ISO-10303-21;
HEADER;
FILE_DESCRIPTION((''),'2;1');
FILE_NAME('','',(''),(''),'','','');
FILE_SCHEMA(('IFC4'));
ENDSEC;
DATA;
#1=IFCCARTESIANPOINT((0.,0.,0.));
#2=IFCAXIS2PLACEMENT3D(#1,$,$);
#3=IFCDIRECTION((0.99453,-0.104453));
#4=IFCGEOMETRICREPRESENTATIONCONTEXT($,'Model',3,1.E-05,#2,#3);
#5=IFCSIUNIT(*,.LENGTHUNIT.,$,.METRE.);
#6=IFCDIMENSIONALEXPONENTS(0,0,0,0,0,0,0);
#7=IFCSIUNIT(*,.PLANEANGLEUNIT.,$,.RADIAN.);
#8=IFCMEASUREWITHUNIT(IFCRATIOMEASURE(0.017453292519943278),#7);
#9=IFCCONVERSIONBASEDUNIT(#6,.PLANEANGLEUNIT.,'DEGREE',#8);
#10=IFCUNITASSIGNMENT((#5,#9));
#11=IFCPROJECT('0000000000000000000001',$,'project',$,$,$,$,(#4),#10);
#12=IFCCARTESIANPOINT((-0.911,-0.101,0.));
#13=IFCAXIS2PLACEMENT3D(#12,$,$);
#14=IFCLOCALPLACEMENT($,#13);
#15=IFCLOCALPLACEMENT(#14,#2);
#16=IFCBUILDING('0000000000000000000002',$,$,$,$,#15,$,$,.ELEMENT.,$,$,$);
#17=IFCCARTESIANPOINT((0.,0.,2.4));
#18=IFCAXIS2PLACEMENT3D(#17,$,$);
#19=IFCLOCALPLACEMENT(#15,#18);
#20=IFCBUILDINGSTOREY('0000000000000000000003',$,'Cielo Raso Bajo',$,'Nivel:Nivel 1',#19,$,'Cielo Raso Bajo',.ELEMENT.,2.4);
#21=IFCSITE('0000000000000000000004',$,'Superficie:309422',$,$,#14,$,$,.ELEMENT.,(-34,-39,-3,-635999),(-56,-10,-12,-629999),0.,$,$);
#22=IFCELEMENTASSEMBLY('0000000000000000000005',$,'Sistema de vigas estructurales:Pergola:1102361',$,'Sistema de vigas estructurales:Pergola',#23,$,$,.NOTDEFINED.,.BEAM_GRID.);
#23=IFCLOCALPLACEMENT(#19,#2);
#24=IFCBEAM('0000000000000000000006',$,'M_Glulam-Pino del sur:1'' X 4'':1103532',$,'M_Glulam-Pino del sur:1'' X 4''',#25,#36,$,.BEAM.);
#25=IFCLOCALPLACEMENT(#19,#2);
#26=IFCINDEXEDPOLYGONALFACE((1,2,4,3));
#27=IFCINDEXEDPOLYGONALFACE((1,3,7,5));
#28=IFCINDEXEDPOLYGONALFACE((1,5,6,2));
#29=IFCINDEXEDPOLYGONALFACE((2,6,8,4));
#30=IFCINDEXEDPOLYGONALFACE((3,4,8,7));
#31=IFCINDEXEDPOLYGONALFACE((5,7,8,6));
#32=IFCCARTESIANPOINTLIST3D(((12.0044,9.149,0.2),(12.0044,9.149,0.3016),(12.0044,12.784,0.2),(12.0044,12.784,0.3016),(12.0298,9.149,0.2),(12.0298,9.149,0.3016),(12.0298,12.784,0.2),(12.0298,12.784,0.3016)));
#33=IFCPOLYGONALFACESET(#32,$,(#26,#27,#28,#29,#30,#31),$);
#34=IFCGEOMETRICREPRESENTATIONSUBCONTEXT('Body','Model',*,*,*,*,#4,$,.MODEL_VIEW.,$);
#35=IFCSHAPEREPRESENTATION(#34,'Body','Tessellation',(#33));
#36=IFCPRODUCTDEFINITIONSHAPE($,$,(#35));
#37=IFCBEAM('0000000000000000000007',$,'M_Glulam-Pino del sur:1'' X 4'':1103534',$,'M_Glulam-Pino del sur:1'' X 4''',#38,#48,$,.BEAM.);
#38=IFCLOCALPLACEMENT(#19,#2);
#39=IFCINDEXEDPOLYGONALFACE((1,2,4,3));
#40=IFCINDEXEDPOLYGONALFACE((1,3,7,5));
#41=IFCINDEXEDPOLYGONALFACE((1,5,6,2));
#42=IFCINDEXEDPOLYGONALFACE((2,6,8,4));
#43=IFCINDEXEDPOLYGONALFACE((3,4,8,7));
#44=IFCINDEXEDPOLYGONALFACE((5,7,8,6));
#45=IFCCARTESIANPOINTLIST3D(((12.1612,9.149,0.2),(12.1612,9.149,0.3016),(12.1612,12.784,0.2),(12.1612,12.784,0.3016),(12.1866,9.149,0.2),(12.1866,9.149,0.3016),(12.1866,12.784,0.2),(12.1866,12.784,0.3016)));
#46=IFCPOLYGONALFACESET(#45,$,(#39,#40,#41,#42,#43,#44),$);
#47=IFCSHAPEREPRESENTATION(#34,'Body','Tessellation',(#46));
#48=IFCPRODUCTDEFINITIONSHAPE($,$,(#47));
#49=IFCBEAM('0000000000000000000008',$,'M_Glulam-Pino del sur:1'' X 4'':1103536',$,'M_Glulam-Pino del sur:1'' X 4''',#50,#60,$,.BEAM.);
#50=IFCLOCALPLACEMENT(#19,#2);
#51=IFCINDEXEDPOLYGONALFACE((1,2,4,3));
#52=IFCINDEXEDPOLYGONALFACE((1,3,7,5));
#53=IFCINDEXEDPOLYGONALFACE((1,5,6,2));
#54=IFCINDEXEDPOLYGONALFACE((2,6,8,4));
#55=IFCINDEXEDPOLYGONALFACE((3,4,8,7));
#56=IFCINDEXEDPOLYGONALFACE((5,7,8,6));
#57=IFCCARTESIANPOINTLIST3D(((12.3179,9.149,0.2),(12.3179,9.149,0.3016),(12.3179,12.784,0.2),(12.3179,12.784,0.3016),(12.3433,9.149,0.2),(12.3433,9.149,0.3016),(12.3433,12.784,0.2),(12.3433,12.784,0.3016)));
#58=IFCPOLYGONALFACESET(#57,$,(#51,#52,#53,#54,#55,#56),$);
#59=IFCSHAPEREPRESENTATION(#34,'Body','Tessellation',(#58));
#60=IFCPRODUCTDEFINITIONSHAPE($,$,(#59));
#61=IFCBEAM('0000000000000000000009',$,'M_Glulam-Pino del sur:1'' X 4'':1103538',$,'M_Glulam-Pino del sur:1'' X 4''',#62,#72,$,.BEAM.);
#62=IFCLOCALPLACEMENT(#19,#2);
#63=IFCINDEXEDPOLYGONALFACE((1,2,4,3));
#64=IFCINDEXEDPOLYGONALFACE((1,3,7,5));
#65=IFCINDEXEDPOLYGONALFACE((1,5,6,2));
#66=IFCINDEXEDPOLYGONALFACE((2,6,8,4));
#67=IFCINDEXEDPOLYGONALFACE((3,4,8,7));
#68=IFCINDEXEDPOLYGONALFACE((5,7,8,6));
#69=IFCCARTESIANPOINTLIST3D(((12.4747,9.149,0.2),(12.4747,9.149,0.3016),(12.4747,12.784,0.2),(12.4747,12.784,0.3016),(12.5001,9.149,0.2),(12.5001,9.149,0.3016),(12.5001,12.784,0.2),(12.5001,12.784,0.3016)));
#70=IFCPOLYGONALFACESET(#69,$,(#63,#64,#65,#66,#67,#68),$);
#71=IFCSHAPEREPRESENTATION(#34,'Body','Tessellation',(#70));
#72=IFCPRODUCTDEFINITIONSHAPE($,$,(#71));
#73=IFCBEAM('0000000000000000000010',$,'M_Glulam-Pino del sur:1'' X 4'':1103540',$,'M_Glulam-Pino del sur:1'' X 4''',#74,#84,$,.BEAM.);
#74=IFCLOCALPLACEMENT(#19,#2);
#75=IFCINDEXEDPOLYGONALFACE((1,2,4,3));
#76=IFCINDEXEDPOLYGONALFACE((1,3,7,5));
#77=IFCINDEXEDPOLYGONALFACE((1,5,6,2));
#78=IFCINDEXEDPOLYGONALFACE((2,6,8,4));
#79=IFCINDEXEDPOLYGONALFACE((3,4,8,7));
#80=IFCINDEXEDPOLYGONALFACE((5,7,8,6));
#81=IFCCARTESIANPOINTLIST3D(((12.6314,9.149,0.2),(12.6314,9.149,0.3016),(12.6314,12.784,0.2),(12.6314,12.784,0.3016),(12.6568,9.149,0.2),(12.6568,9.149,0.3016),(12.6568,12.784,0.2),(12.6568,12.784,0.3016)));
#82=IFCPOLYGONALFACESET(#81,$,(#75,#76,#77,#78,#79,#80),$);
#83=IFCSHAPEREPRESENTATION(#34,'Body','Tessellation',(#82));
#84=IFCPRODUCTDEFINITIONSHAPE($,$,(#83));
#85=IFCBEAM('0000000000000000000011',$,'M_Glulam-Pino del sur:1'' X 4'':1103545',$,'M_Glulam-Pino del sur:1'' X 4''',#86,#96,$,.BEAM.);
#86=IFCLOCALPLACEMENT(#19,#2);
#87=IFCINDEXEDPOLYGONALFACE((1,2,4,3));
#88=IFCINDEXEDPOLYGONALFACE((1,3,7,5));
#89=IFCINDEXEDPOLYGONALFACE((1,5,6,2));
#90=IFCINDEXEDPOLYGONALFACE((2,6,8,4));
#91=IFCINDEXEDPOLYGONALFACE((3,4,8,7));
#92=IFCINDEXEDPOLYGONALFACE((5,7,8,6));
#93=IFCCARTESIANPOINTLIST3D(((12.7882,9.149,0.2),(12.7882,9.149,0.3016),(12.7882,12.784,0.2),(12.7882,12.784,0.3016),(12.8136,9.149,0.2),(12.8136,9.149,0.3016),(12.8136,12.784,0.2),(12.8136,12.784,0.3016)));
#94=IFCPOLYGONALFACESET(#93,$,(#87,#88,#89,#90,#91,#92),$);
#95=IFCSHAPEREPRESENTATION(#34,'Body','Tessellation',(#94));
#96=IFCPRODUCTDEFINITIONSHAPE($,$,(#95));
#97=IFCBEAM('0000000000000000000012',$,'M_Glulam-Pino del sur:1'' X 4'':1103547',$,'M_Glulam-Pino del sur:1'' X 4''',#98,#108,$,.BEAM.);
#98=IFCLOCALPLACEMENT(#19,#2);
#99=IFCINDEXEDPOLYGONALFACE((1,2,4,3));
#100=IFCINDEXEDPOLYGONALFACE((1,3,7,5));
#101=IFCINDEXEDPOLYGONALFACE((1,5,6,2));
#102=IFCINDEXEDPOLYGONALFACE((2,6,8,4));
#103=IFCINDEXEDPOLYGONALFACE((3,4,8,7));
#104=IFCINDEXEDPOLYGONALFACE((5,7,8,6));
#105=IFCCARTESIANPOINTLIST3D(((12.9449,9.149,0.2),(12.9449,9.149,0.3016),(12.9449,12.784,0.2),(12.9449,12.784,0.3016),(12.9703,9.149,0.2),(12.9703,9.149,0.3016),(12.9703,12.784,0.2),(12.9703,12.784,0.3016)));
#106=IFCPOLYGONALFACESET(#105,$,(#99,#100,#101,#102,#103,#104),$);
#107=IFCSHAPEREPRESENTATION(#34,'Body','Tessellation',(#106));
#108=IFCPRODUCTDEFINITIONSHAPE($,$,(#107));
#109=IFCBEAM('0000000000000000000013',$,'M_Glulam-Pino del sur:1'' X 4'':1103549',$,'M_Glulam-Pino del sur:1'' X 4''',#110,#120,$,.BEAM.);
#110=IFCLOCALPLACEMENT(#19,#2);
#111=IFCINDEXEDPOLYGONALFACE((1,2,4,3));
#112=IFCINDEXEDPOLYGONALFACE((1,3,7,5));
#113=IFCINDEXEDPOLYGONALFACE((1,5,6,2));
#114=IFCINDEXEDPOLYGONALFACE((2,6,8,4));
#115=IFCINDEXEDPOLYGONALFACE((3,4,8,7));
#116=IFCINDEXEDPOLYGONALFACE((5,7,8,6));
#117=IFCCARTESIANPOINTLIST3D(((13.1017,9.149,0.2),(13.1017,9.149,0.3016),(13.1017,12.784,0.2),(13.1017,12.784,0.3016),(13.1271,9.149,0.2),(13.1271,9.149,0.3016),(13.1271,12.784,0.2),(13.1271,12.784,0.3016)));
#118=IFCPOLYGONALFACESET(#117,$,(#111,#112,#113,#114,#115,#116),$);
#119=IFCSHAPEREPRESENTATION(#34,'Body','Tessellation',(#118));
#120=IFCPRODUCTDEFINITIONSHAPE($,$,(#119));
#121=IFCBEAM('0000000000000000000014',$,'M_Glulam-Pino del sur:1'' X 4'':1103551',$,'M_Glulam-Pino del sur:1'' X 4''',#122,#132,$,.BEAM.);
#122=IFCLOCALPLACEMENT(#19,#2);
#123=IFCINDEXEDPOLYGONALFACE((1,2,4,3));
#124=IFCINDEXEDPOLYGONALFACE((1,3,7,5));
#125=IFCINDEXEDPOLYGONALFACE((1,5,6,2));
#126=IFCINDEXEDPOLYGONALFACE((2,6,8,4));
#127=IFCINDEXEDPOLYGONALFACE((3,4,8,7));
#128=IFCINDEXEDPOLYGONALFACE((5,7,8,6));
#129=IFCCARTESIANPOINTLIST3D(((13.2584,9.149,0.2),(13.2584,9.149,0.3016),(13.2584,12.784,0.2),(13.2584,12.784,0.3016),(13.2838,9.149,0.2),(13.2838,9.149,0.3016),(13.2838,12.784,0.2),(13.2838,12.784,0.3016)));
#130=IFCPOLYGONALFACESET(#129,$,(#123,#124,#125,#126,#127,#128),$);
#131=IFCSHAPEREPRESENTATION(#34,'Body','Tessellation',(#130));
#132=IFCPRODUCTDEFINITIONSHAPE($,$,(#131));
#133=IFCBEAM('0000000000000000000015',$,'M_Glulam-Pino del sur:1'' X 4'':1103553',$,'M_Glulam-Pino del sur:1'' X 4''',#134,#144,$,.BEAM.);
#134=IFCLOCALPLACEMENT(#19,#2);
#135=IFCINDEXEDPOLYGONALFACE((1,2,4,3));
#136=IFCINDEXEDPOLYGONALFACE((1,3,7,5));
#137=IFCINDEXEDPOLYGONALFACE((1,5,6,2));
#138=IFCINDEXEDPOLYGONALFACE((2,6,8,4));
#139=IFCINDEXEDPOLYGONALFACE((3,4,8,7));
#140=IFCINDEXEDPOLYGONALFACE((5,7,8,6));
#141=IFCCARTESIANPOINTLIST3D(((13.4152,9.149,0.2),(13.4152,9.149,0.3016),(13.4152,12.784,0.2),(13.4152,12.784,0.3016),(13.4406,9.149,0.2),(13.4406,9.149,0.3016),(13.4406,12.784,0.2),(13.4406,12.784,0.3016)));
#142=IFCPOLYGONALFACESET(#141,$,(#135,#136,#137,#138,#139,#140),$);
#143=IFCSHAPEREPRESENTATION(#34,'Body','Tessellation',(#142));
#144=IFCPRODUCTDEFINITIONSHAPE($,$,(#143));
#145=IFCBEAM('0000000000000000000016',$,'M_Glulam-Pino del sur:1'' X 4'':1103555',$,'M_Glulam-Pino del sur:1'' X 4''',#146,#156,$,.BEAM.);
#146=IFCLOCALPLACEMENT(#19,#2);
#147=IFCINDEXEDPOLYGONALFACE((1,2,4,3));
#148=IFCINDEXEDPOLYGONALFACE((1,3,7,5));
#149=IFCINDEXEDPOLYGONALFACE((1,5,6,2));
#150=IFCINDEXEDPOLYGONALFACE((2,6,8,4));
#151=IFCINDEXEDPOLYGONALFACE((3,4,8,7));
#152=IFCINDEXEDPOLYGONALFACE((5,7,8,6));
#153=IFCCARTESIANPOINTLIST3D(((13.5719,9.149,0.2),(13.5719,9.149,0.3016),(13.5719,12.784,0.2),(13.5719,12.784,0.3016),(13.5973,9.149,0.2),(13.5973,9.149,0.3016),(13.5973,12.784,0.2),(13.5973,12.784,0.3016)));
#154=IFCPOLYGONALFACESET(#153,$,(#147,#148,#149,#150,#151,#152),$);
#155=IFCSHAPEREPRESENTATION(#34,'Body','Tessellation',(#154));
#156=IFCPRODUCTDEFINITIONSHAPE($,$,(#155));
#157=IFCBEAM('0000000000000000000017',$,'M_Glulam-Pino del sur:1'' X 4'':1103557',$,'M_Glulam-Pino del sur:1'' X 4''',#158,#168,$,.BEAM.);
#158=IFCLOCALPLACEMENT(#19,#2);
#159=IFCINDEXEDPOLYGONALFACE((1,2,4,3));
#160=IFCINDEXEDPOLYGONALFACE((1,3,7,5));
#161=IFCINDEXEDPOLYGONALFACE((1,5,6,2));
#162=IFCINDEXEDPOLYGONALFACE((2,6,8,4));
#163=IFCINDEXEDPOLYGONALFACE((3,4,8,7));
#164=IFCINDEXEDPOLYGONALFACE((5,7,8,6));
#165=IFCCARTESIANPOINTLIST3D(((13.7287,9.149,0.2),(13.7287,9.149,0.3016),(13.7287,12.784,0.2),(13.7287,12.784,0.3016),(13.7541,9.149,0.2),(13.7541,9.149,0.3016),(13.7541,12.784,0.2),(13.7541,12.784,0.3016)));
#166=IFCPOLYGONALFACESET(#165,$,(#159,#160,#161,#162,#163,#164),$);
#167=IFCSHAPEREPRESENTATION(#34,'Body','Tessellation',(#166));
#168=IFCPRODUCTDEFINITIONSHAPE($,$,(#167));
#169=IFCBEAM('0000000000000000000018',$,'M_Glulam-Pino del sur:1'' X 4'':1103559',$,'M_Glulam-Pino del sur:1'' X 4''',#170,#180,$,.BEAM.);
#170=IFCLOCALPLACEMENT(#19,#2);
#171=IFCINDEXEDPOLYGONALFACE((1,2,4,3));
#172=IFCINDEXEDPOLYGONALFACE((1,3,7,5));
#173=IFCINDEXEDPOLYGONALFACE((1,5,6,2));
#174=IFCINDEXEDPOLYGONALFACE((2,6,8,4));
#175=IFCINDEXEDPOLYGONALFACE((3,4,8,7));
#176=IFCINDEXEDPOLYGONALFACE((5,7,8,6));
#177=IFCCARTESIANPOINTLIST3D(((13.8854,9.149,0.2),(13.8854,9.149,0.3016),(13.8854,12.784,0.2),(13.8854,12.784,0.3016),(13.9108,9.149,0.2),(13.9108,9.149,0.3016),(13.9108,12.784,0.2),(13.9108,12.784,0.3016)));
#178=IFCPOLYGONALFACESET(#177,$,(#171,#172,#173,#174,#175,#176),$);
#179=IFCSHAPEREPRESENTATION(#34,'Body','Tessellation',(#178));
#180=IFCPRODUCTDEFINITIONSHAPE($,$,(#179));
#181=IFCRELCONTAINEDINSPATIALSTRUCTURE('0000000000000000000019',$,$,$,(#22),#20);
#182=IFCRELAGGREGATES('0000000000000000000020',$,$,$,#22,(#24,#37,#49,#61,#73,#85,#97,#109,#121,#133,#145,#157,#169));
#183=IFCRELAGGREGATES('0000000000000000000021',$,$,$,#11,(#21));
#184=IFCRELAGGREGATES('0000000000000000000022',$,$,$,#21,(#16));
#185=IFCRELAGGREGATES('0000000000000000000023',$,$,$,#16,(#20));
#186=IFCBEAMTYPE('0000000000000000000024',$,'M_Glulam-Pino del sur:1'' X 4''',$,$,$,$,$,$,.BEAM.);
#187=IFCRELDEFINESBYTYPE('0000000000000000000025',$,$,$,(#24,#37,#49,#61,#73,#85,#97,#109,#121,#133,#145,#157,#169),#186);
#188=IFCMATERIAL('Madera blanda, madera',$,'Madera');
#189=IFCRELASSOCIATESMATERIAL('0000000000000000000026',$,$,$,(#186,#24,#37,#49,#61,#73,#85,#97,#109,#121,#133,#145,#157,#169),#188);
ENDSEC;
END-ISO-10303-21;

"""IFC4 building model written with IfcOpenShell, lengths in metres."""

from ifc_helpers import new_model, entity, si_unit, converted_unit, direction, frame, origin, origin_2d_with_axis, place, context, subcontext, project, spatial, polyline, segment, composite_curve, rectangle, outline, extrude, source, transform, mapped, material, material_profile, profile_set, profile_usage, type_object, type_shapes, element, aggregate, save


model = new_model("IFC4")

# Units and contexts
model_context = context("Model", 3, precision=1e-05, world=origin(), true_north=direction((0.99453, -0.104453)))
body_context = subcontext(model_context, "Body", "Model", "MODEL_VIEW")
ifc_project = project(units=[si_unit("LENGTHUNIT", "METRE"), converted_unit("PLANEANGLEUNIT", "DEGREE", entity("IfcRatioMeasure", 0.017453292519943278), si_unit("PLANEANGLEUNIT", "RADIAN"), dimensions=[0, 0, 0, 0, 0, 0, 0])], contexts=[model_context])

# Site, building, storey
site_placement = place(None, frame((-0.911, -0.101, 0.0)))
site = spatial("IfcSite", under=ifc_project, at=site_placement, Name="Superficie:309422", CompositionType="ELEMENT", RefLatitude=(-34, -39, -3, -635999), RefLongitude=(-56, -10, -12, -629999), RefElevation=0.0)
building_placement = place(site_placement, origin())
building = spatial("IfcBuilding", under=site, at=building_placement, CompositionType="ELEMENT")
storey_placement = place(building_placement, frame((0.0, 0.0, 2.4)))
storey = spatial("IfcBuildingStorey", under=building, at=storey_placement, Name="Cielo Raso Bajo", ObjectType="Nivel:Nivel 1", LongName="Cielo Raso Bajo", CompositionType="ELEMENT", Elevation=2.4)

# Element assembly, beams
assembly_placement = place(storey_placement, origin())
assembly = element("IfcElementAssembly", 1, at=assembly_placement, inside=storey, Name="Sistema de vigas estructurales:Pergola:1102361", ObjectType="Sistema de vigas estructurales:Pergola", AssemblyPlace="NOTDEFINED", PredefinedType="BEAM_GRID")
ifc_material = material(Name="Madera blanda, madera", Category="Madera")
ifc_material_profile_1 = material_profile(ifc_material, outline(composite_curve([segment(polyline([(-0.0127, 0.0508, 0.0), (0.0127, 0.0508, 0.0)]), True, "CONTINUOUS"), segment(polyline([(0.0127, 0.0508, 0.0), (0.0127, -0.0508, 0.0)]), True, "CONTINUOUS"), segment(polyline([(0.0127, -0.0508, 0.0), (-0.0127, -0.0508, 0.0)]), True, "CONTINUOUS"), segment(polyline([(-0.0127, -0.0508, 0.0), (-0.0127, 0.0508, 0.0)]), True, "CONTINUOUS")], self_intersect=False), kind="CURVE"), Name="1' X 4'")
ifc_material_profile_2 = material_profile(ifc_material, outline(composite_curve([segment(polyline([(2.5145, -0.0127, -0.0508), (2.5145, -0.0127, 0.0508)]), True, "CONTINUOUS"), segment(polyline([(2.5145, -0.0127, 0.0508), (-2.5145, -0.0127, 0.0508)]), True, "CONTINUOUS"), segment(polyline([(-2.5145, -0.0127, 0.0508), (-2.5145, -0.0127, -0.0508)]), True, "CONTINUOUS"), segment(polyline([(-2.5145, -0.0127, -0.0508), (2.5145, -0.0127, -0.0508)]), True, "CONTINUOUS")], self_intersect=False), kind="CURVE"), Name="1' X 4'")
ifc_profile_set = profile_set([ifc_material_profile_1, ifc_material_profile_2], Name="1' X 4'")
ifc_profile_usage_1 = profile_usage(ifc_profile_set, cardinal=8)
beam_type = type_object("IfcBeamType", Name="M_Glulam-Pino del sur:1' X 4'", PredefinedType="BEAM", material=ifc_profile_set)
shared_shape = source(origin(), body_context, "Body", "SweptSolid", [
    extrude(rectangle(XDim=0.1016, YDim=0.0254, at=origin_2d_with_axis()), frame((-1.7485, 0.0, 0.0), z_axis=(1.0, 0.0, 0.0), x_axis=(0.0, 0.0, -1.0)), (0.0, 0.0, 1.0), 3.635),
])
type_shapes(beam_type, [shared_shape])
beam_1_placement = place(assembly_placement, frame((12.0171, 10.8975, 0.2508), z_axis=(0.0, 0.0, 1.0), x_axis=(0.0, 1.0, 0.0)))
beam_1 = element("IfcBeam", 2, at=beam_1_placement, type_object=beam_type, material=ifc_profile_usage_1, Name="M_Glulam-Pino del sur:1' X 4':1103532", ObjectType="M_Glulam-Pino del sur:1' X 4'", PredefinedType="BEAM", context=body_context, shape_type="MappedRepresentation", body=[
    mapped(shared_shape, transform((0.0, 0.0, 0.0), scale=1.0)),
])
ifc_profile_usage_2 = profile_usage(ifc_profile_set, cardinal=8)
beam_2_placement = place(assembly_placement, frame((12.1739, 10.8975, 0.2508), z_axis=(0.0, 0.0, 1.0), x_axis=(0.0, 1.0, 0.0)))
beam_2 = element("IfcBeam", 3, at=beam_2_placement, type_object=beam_type, material=ifc_profile_usage_2, Name="M_Glulam-Pino del sur:1' X 4':1103534", ObjectType="M_Glulam-Pino del sur:1' X 4'", PredefinedType="BEAM", context=body_context, shape_type="MappedRepresentation", body=[
    mapped(shared_shape, transform((0.0, 0.0, 0.0), scale=1.0)),
])
ifc_profile_usage_3 = profile_usage(ifc_profile_set, cardinal=8)
beam_3_placement = place(assembly_placement, frame((12.3306, 10.8975, 0.2508), z_axis=(0.0, 0.0, 1.0), x_axis=(0.0, 1.0, 0.0)))
beam_3 = element("IfcBeam", 4, at=beam_3_placement, type_object=beam_type, material=ifc_profile_usage_3, Name="M_Glulam-Pino del sur:1' X 4':1103536", ObjectType="M_Glulam-Pino del sur:1' X 4'", PredefinedType="BEAM", context=body_context, shape_type="MappedRepresentation", body=[
    mapped(shared_shape, transform((0.0, 0.0, 0.0), scale=1.0)),
])
ifc_profile_usage_4 = profile_usage(ifc_profile_set, cardinal=8)
beam_4_placement = place(assembly_placement, frame((12.4874, 10.8975, 0.2508), z_axis=(0.0, 0.0, 1.0), x_axis=(0.0, 1.0, 0.0)))
beam_4 = element("IfcBeam", 5, at=beam_4_placement, type_object=beam_type, material=ifc_profile_usage_4, Name="M_Glulam-Pino del sur:1' X 4':1103538", ObjectType="M_Glulam-Pino del sur:1' X 4'", PredefinedType="BEAM", context=body_context, shape_type="MappedRepresentation", body=[
    mapped(shared_shape, transform((0.0, 0.0, 0.0), scale=1.0)),
])
ifc_profile_usage_5 = profile_usage(ifc_profile_set, cardinal=8)
beam_5_placement = place(assembly_placement, frame((12.6441, 10.8975, 0.2508), z_axis=(0.0, 0.0, 1.0), x_axis=(0.0, 1.0, 0.0)))
beam_5 = element("IfcBeam", 6, at=beam_5_placement, type_object=beam_type, material=ifc_profile_usage_5, Name="M_Glulam-Pino del sur:1' X 4':1103540", ObjectType="M_Glulam-Pino del sur:1' X 4'", PredefinedType="BEAM", context=body_context, shape_type="MappedRepresentation", body=[
    mapped(shared_shape, transform((0.0, 0.0, 0.0), scale=1.0)),
])
ifc_profile_usage_6 = profile_usage(ifc_profile_set, cardinal=8)
beam_6_placement = place(assembly_placement, frame((12.8009, 10.8975, 0.2508), z_axis=(0.0, 0.0, 1.0), x_axis=(0.0, 1.0, 0.0)))
beam_6 = element("IfcBeam", 7, at=beam_6_placement, type_object=beam_type, material=ifc_profile_usage_6, Name="M_Glulam-Pino del sur:1' X 4':1103545", ObjectType="M_Glulam-Pino del sur:1' X 4'", PredefinedType="BEAM", context=body_context, shape_type="MappedRepresentation", body=[
    mapped(shared_shape, transform((0.0, 0.0, 0.0), scale=1.0)),
])
ifc_profile_usage_7 = profile_usage(ifc_profile_set, cardinal=8)
beam_7_placement = place(assembly_placement, frame((12.9576, 10.8975, 0.2508), z_axis=(0.0, 0.0, 1.0), x_axis=(0.0, 1.0, 0.0)))
beam_7 = element("IfcBeam", 8, at=beam_7_placement, type_object=beam_type, material=ifc_profile_usage_7, Name="M_Glulam-Pino del sur:1' X 4':1103547", ObjectType="M_Glulam-Pino del sur:1' X 4'", PredefinedType="BEAM", context=body_context, shape_type="MappedRepresentation", body=[
    mapped(shared_shape, transform((0.0, 0.0, 0.0), scale=1.0)),
])
ifc_profile_usage_8 = profile_usage(ifc_profile_set, cardinal=8)
beam_8_placement = place(assembly_placement, frame((13.1144, 10.8975, 0.2508), z_axis=(0.0, 0.0, 1.0), x_axis=(0.0, 1.0, 0.0)))
beam_8 = element("IfcBeam", 9, at=beam_8_placement, type_object=beam_type, material=ifc_profile_usage_8, Name="M_Glulam-Pino del sur:1' X 4':1103549", ObjectType="M_Glulam-Pino del sur:1' X 4'", PredefinedType="BEAM", context=body_context, shape_type="MappedRepresentation", body=[
    mapped(shared_shape, transform((0.0, 0.0, 0.0), scale=1.0)),
])
ifc_profile_usage_9 = profile_usage(ifc_profile_set, cardinal=8)
beam_9_placement = place(assembly_placement, frame((13.2711, 10.8975, 0.2508), z_axis=(0.0, 0.0, 1.0), x_axis=(0.0, 1.0, 0.0)))
beam_9 = element("IfcBeam", 10, at=beam_9_placement, type_object=beam_type, material=ifc_profile_usage_9, Name="M_Glulam-Pino del sur:1' X 4':1103551", ObjectType="M_Glulam-Pino del sur:1' X 4'", PredefinedType="BEAM", context=body_context, shape_type="MappedRepresentation", body=[
    mapped(shared_shape, transform((0.0, 0.0, 0.0), scale=1.0)),
])
ifc_profile_usage_10 = profile_usage(ifc_profile_set, cardinal=8)
beam_10_placement = place(assembly_placement, frame((13.4279, 10.8975, 0.2508), z_axis=(0.0, 0.0, 1.0), x_axis=(0.0, 1.0, 0.0)))
beam_10 = element("IfcBeam", 11, at=beam_10_placement, type_object=beam_type, material=ifc_profile_usage_10, Name="M_Glulam-Pino del sur:1' X 4':1103553", ObjectType="M_Glulam-Pino del sur:1' X 4'", PredefinedType="BEAM", context=body_context, shape_type="MappedRepresentation", body=[
    mapped(shared_shape, transform((0.0, 0.0, 0.0), scale=1.0)),
])
ifc_profile_usage_11 = profile_usage(ifc_profile_set, cardinal=8)
beam_11_placement = place(assembly_placement, frame((13.5846, 10.8975, 0.2508), z_axis=(0.0, 0.0, 1.0), x_axis=(0.0, 1.0, 0.0)))
beam_11 = element("IfcBeam", 12, at=beam_11_placement, type_object=beam_type, material=ifc_profile_usage_11, Name="M_Glulam-Pino del sur:1' X 4':1103555", ObjectType="M_Glulam-Pino del sur:1' X 4'", PredefinedType="BEAM", context=body_context, shape_type="MappedRepresentation", body=[
    mapped(shared_shape, transform((0.0, 0.0, 0.0), scale=1.0)),
])
ifc_profile_usage_12 = profile_usage(ifc_profile_set, cardinal=8)
beam_12_placement = place(assembly_placement, frame((13.7414, 10.8975, 0.2508), z_axis=(0.0, 0.0, 1.0), x_axis=(0.0, 1.0, 0.0)))
beam_12 = element("IfcBeam", 13, at=beam_12_placement, type_object=beam_type, material=ifc_profile_usage_12, Name="M_Glulam-Pino del sur:1' X 4':1103557", ObjectType="M_Glulam-Pino del sur:1' X 4'", PredefinedType="BEAM", context=body_context, shape_type="MappedRepresentation", body=[
    mapped(shared_shape, transform((0.0, 0.0, 0.0), scale=1.0)),
])
ifc_profile_usage_13 = profile_usage(ifc_profile_set, cardinal=8)
beam_13_placement = place(assembly_placement, frame((13.8981, 10.8975, 0.2508), z_axis=(0.0, 0.0, 1.0), x_axis=(0.0, 1.0, 0.0)))
beam_13 = element("IfcBeam", 14, at=beam_13_placement, type_object=beam_type, material=ifc_profile_usage_13, Name="M_Glulam-Pino del sur:1' X 4':1103559", ObjectType="M_Glulam-Pino del sur:1' X 4'", PredefinedType="BEAM", context=body_context, shape_type="MappedRepresentation", body=[
    mapped(shared_shape, transform((0.0, 0.0, 0.0), scale=1.0)),
])
aggregate(assembly, [beam_1, beam_2, beam_3, beam_4, beam_5, beam_6, beam_7, beam_8, beam_9, beam_10, beam_11, beam_12, beam_13])

save(model, "model.ifc")
